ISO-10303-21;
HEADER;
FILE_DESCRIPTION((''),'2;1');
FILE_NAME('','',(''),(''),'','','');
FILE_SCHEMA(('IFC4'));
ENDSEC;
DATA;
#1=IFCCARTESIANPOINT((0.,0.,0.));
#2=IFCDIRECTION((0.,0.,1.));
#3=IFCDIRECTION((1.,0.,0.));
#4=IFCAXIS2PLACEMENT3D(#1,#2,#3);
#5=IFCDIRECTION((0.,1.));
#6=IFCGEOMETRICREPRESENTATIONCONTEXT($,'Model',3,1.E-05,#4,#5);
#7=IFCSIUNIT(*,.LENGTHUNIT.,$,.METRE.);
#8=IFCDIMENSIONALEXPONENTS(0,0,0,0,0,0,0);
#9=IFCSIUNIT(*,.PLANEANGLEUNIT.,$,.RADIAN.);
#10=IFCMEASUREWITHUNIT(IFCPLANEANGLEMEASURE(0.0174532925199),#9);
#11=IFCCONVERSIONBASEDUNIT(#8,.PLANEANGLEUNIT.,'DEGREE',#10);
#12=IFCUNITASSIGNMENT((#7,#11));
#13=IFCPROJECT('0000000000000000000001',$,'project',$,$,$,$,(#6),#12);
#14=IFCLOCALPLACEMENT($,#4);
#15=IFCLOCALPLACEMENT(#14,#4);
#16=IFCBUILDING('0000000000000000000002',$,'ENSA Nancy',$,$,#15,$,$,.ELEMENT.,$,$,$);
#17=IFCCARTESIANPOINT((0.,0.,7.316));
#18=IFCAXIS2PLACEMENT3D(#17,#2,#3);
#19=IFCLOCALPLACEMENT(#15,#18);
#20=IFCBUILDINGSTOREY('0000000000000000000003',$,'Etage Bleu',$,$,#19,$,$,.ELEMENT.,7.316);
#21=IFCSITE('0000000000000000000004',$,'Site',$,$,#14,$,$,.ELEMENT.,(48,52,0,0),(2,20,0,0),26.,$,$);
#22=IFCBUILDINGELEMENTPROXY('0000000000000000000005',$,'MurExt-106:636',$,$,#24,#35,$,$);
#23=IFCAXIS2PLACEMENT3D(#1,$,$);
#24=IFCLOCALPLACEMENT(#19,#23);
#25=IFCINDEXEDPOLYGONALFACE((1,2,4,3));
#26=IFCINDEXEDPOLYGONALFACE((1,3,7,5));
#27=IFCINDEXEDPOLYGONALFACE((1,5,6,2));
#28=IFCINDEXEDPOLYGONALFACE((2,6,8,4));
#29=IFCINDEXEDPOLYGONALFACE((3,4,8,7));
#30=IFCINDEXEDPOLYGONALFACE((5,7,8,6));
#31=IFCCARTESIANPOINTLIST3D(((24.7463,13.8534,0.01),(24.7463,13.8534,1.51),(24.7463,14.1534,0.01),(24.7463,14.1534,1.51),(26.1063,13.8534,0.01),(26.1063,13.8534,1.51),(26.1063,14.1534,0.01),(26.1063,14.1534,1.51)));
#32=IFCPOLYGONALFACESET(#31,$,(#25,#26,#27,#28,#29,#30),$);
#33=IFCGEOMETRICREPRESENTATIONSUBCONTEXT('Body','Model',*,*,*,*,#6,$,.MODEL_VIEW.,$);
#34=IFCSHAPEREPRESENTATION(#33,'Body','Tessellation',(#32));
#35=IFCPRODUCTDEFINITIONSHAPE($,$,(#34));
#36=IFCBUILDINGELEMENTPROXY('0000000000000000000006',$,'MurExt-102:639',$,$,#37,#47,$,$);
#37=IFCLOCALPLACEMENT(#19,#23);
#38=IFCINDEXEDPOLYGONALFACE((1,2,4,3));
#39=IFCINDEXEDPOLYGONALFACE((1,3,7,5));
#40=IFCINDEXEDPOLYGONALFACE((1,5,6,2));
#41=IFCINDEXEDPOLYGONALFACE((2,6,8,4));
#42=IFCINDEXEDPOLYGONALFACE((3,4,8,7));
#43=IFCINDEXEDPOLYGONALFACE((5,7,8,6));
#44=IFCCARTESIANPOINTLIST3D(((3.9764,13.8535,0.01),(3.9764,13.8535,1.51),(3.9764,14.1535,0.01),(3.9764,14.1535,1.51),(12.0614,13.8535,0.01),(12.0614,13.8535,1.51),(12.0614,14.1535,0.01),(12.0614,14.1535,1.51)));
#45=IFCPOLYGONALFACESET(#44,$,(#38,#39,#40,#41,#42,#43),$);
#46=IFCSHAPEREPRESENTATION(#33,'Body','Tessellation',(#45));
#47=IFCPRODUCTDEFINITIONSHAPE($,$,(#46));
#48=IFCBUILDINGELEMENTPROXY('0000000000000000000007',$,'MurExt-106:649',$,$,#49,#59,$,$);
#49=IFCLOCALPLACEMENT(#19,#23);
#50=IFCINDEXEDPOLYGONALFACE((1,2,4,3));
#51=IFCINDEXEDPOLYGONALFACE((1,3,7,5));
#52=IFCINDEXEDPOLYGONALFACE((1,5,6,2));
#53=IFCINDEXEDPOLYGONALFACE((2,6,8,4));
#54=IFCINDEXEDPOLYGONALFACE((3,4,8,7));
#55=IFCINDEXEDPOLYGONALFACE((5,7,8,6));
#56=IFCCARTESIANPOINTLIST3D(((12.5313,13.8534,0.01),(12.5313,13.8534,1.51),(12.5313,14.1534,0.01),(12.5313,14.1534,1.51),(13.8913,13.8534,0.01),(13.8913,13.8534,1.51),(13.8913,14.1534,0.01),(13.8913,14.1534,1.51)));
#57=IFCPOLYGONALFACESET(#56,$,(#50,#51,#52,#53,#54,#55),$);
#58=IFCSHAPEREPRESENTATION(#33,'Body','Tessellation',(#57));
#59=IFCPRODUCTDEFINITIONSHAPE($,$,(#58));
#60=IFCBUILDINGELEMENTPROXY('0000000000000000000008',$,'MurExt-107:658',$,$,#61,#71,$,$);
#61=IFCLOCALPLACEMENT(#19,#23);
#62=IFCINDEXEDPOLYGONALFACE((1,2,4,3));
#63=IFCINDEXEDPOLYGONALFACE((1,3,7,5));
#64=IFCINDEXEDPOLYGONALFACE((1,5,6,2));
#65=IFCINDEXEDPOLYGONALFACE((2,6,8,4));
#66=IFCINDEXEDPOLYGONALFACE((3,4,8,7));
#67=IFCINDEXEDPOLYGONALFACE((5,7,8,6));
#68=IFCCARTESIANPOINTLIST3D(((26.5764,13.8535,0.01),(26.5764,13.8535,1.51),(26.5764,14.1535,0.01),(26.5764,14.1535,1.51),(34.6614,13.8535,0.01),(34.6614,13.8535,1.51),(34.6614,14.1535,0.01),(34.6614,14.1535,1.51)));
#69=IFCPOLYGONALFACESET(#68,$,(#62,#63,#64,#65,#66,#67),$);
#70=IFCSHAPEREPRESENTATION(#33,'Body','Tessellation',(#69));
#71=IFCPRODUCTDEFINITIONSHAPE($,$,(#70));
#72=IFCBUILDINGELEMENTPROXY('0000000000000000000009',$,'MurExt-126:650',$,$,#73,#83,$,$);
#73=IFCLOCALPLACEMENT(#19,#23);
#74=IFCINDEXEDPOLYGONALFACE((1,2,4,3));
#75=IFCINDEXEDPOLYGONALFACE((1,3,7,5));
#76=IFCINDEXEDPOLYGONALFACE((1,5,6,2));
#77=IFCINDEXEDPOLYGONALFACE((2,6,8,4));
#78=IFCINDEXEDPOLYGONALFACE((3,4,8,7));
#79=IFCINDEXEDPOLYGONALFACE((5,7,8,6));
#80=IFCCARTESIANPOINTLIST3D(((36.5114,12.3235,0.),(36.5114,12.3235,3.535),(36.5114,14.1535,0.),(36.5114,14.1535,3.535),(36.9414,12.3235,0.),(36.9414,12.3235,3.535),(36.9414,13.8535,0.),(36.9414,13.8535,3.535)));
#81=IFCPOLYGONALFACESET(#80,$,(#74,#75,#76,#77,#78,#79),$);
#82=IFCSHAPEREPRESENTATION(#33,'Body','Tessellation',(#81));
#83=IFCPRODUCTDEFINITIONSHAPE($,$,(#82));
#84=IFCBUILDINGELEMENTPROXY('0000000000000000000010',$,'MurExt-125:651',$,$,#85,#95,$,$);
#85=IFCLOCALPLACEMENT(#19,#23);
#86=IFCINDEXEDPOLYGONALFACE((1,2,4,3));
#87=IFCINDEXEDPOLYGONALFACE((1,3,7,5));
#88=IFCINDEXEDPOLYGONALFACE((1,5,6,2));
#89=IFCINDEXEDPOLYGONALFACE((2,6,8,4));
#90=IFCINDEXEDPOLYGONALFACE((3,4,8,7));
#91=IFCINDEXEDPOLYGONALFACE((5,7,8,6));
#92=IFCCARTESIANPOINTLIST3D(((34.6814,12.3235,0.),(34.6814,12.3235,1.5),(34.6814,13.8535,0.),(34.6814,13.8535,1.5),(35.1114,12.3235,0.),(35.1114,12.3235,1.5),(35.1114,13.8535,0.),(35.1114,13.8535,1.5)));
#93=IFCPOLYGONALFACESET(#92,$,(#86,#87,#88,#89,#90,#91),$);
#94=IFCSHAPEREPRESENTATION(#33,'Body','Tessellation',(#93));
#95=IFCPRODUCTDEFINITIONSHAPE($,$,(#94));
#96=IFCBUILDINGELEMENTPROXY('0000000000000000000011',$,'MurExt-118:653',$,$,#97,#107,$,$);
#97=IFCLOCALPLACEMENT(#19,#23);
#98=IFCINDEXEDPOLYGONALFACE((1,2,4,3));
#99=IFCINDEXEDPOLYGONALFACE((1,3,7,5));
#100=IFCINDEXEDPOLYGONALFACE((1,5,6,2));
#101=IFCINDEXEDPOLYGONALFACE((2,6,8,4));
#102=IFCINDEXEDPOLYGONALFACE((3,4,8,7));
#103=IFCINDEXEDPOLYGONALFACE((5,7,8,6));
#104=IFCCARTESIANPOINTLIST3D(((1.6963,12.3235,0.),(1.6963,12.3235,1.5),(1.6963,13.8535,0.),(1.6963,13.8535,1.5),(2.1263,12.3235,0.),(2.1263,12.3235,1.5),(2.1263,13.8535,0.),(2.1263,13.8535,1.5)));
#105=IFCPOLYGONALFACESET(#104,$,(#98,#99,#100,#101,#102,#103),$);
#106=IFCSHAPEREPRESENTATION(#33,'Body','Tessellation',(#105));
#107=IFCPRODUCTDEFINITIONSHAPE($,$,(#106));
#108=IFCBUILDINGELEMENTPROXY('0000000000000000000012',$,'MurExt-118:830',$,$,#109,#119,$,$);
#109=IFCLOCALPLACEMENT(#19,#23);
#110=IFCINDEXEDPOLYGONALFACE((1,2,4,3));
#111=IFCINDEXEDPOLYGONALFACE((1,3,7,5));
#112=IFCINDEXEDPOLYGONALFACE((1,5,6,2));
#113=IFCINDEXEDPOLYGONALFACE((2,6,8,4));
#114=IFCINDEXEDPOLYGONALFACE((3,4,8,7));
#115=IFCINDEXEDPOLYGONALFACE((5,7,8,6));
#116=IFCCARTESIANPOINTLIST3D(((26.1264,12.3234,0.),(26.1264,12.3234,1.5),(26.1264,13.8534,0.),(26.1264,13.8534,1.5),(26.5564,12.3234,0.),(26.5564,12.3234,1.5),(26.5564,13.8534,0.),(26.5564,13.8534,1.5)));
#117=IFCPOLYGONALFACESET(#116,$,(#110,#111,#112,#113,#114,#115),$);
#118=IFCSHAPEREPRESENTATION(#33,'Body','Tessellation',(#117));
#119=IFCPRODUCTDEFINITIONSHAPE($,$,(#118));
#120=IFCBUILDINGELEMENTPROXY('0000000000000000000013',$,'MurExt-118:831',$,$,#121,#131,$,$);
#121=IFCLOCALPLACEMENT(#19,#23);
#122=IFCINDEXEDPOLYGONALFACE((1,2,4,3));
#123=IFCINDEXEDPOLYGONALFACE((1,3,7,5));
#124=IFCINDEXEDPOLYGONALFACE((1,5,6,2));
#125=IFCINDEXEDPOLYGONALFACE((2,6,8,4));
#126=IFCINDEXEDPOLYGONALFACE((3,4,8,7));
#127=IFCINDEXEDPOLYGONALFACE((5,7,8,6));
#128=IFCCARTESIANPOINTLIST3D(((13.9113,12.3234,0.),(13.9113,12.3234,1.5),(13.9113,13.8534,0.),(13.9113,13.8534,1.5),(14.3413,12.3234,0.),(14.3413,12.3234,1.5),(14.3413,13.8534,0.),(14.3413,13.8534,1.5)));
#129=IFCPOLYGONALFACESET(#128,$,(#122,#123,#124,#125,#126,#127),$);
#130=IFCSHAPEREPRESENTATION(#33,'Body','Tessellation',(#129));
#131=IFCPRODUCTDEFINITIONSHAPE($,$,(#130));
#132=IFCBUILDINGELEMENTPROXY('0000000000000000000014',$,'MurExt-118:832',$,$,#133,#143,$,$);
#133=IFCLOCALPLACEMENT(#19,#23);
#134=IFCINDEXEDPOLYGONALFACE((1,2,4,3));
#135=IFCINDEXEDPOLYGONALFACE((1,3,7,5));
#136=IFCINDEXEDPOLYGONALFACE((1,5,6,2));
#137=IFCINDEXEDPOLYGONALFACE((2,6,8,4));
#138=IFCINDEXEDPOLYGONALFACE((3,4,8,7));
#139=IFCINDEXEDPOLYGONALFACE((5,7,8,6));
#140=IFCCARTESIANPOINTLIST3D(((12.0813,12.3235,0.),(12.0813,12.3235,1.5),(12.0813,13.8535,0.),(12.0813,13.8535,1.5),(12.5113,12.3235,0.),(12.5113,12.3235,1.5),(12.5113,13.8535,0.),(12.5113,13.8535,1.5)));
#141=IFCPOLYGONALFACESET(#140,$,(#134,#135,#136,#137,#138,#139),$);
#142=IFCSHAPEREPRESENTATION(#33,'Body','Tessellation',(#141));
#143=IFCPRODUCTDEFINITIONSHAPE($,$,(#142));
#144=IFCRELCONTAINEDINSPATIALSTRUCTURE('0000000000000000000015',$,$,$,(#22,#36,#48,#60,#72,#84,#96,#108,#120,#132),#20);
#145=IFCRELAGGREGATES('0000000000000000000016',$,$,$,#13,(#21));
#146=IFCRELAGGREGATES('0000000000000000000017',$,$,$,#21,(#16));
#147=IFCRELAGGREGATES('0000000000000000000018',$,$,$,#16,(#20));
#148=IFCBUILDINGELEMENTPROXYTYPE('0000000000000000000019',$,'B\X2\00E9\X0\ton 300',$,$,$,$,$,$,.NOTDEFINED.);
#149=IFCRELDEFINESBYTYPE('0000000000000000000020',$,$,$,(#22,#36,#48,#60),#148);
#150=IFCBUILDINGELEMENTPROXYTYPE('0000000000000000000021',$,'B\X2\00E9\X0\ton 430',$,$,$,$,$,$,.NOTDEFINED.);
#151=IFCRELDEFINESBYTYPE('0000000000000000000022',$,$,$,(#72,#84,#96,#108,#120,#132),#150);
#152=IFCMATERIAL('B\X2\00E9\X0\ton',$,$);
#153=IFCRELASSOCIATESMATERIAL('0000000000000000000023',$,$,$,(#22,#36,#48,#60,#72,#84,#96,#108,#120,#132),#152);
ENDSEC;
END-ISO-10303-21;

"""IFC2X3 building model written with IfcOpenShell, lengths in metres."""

from ifc_helpers import new_model, entity, si_unit, converted_unit, direction, frame, origin_with_axes, place, context, subcontext, project, spatial, polyline, outline, extrude, material, type_object, element, save


model = new_model("IFC2X3")

# Units and contexts
model_context = context("Model", 3, precision=1e-05, world=origin_with_axes(), true_north=direction((0.0, 1.0)))
body_context = subcontext(model_context, "Body", "Model", "MODEL_VIEW")
ifc_project = project(units=[si_unit("LENGTHUNIT", "METRE"), converted_unit("PLANEANGLEUNIT", "DEGREE", entity("IfcPlaneAngleMeasure", 0.0174532925199), si_unit("PLANEANGLEUNIT", "RADIAN"), dimensions=[0, 0, 0, 0, 0, 0, 0])], contexts=[model_context])

# Site, building, storey
site_placement = place(None, origin_with_axes())
site = spatial("IfcSite", under=ifc_project, at=site_placement, Name="Site", CompositionType="ELEMENT", RefLatitude=(48, 52, 0, 0), RefLongitude=(2, 20, 0, 0), RefElevation=26.0)
building_placement = place(site_placement, origin_with_axes())
building = spatial("IfcBuilding", under=site, at=building_placement, Name="ENSA Nancy", CompositionType="ELEMENT")
storey_placement = place(building_placement, frame((0.0, 0.0, 7.316), z_axis=(0.0, 0.0, 1.0), x_axis=(1.0, 0.0, 0.0)))
storey = spatial("IfcBuildingStorey", under=building, at=storey_placement, Name="Etage Bleu", CompositionType="ELEMENT", Elevation=7.316)

# Building element proxies
ifc_material = material(Name="Béton")
building_element_proxy_type_1 = type_object("IfcBuildingElementProxyType", Name="Béton 300", PredefinedType="NOTDEFINED")
proxy_1_placement = place(storey_placement, frame((24.7463, 13.8534, 0.01), z_axis=(0.0, 0.0, 1.0), x_axis=(1.0, 0.0, 0.0)))
element("IfcBuildingElementProxy", 1, at=proxy_1_placement, inside=storey, type_object=building_element_proxy_type_1, material=ifc_material, Name="MurExt-106:636", context=body_context, shape_type="SweptSolid", body=[
    extrude(outline(polyline([(0.0, 0.0), (1.36, 0.0), (1.36, 0.3), (0.0, 0.3), (0.0, 0.0)])), origin_with_axes(), (0.0, 0.0, 1.0), 1.5),
])
proxy_2_placement = place(storey_placement, frame((3.9764, 13.8535, 0.01), z_axis=(0.0, 0.0, 1.0), x_axis=(1.0, 0.000001, 0.0)))
element("IfcBuildingElementProxy", 2, at=proxy_2_placement, inside=storey, type_object=building_element_proxy_type_1, material=ifc_material, Name="MurExt-102:639", context=body_context, shape_type="SweptSolid", body=[
    extrude(outline(polyline([(0.0, 0.0), (8.085, 0.0), (8.085, 0.3), (0.0, 0.3), (0.0, 0.0)])), origin_with_axes(), (0.0, 0.0, 1.0), 1.5),
])
proxy_3_placement = place(storey_placement, frame((12.5313, 13.8534, 0.01), z_axis=(0.0, 0.0, 1.0), x_axis=(1.0, 0.0, 0.0)))
element("IfcBuildingElementProxy", 3, at=proxy_3_placement, inside=storey, type_object=building_element_proxy_type_1, material=ifc_material, Name="MurExt-106:649", context=body_context, shape_type="SweptSolid", body=[
    extrude(outline(polyline([(0.0, 0.0), (1.36, 0.0), (1.36, 0.3), (0.0, 0.3), (0.0, 0.0)])), origin_with_axes(), (0.0, 0.0, 1.0), 1.5),
])
proxy_4_placement = place(storey_placement, frame((26.5764, 13.8535, 0.01), z_axis=(0.0, 0.0, 1.0), x_axis=(1.0, 0.0, 0.0)))
element("IfcBuildingElementProxy", 4, at=proxy_4_placement, inside=storey, type_object=building_element_proxy_type_1, material=ifc_material, Name="MurExt-107:658", context=body_context, shape_type="SweptSolid", body=[
    extrude(outline(polyline([(0.0, 0.0), (8.085, 0.0), (8.085, 0.3), (0.0, 0.3), (0.0, 0.0)])), origin_with_axes(), (0.0, 0.0, 1.0), 1.5),
])
building_element_proxy_type_2 = type_object("IfcBuildingElementProxyType", Name="Béton 430", PredefinedType="NOTDEFINED")
proxy_5_placement = place(storey_placement, frame((36.5114, 13.8535, 0.0), z_axis=(0.0, 0.0, 1.0), x_axis=(0.0, -1.0, 0.0)))
element("IfcBuildingElementProxy", 5, at=proxy_5_placement, inside=storey, type_object=building_element_proxy_type_2, material=ifc_material, Name="MurExt-126:650", context=body_context, shape_type="SweptSolid", body=[
    extrude(outline(polyline([(-0.3, 0.0), (1.53, 0.0), (1.53, 0.43), (0.0, 0.43), (-0.3, 0.0)])), origin_with_axes(), (0.0, 0.0, 1.0), 3.535),
])
proxy_6_placement = place(storey_placement, frame((34.6814, 13.8535, 0.0), z_axis=(0.0, 0.0, 1.0), x_axis=(0.0, -1.0, 0.0)))
element("IfcBuildingElementProxy", 6, at=proxy_6_placement, inside=storey, type_object=building_element_proxy_type_2, material=ifc_material, Name="MurExt-125:651", context=body_context, shape_type="SweptSolid", body=[
    extrude(outline(polyline([(0.0, 0.0), (1.53, 0.0), (1.53, 0.43), (0.0, 0.43), (0.0, 0.0)])), origin_with_axes(), (0.0, 0.0, 1.0), 1.5),
])
for number, where, z_axis, x_axis, name in (
    (7, (1.6963, 13.8535, 0.0), (0.0, 0.0, 1.0), (0.0, -1.0, 0.0), "MurExt-118:653"),
    (8, (26.1264, 13.8534, 0.0), (0.0, 0.0, 1.0), (0.0, -1.0, 0.0), "MurExt-118:830"),
    (9, (13.9113, 13.8534, 0.0), (0.0, 0.0, 1.0), (0.0, -1.0, 0.0), "MurExt-118:831"),
    (10, (12.0813, 13.8535, 0.0), (0.0, 0.0, 1.0), (0.0, -1.0, 0.0), "MurExt-118:832"),
):
    element("IfcBuildingElementProxy", number, at=place(storey_placement, frame(where, z_axis=z_axis, x_axis=x_axis)), inside=storey, type_object=building_element_proxy_type_2, material=ifc_material, Name=name, context=body_context, shape_type="SweptSolid", body=[
        extrude(outline(polyline([(0.0, 0.0), (1.53, 0.0), (1.53, 0.43), (0.0, 0.43), (0.0, 0.0)])), origin_with_axes(), (0.0, 0.0, 1.0), 1.5),
    ])

save(model, "model.ifc")
